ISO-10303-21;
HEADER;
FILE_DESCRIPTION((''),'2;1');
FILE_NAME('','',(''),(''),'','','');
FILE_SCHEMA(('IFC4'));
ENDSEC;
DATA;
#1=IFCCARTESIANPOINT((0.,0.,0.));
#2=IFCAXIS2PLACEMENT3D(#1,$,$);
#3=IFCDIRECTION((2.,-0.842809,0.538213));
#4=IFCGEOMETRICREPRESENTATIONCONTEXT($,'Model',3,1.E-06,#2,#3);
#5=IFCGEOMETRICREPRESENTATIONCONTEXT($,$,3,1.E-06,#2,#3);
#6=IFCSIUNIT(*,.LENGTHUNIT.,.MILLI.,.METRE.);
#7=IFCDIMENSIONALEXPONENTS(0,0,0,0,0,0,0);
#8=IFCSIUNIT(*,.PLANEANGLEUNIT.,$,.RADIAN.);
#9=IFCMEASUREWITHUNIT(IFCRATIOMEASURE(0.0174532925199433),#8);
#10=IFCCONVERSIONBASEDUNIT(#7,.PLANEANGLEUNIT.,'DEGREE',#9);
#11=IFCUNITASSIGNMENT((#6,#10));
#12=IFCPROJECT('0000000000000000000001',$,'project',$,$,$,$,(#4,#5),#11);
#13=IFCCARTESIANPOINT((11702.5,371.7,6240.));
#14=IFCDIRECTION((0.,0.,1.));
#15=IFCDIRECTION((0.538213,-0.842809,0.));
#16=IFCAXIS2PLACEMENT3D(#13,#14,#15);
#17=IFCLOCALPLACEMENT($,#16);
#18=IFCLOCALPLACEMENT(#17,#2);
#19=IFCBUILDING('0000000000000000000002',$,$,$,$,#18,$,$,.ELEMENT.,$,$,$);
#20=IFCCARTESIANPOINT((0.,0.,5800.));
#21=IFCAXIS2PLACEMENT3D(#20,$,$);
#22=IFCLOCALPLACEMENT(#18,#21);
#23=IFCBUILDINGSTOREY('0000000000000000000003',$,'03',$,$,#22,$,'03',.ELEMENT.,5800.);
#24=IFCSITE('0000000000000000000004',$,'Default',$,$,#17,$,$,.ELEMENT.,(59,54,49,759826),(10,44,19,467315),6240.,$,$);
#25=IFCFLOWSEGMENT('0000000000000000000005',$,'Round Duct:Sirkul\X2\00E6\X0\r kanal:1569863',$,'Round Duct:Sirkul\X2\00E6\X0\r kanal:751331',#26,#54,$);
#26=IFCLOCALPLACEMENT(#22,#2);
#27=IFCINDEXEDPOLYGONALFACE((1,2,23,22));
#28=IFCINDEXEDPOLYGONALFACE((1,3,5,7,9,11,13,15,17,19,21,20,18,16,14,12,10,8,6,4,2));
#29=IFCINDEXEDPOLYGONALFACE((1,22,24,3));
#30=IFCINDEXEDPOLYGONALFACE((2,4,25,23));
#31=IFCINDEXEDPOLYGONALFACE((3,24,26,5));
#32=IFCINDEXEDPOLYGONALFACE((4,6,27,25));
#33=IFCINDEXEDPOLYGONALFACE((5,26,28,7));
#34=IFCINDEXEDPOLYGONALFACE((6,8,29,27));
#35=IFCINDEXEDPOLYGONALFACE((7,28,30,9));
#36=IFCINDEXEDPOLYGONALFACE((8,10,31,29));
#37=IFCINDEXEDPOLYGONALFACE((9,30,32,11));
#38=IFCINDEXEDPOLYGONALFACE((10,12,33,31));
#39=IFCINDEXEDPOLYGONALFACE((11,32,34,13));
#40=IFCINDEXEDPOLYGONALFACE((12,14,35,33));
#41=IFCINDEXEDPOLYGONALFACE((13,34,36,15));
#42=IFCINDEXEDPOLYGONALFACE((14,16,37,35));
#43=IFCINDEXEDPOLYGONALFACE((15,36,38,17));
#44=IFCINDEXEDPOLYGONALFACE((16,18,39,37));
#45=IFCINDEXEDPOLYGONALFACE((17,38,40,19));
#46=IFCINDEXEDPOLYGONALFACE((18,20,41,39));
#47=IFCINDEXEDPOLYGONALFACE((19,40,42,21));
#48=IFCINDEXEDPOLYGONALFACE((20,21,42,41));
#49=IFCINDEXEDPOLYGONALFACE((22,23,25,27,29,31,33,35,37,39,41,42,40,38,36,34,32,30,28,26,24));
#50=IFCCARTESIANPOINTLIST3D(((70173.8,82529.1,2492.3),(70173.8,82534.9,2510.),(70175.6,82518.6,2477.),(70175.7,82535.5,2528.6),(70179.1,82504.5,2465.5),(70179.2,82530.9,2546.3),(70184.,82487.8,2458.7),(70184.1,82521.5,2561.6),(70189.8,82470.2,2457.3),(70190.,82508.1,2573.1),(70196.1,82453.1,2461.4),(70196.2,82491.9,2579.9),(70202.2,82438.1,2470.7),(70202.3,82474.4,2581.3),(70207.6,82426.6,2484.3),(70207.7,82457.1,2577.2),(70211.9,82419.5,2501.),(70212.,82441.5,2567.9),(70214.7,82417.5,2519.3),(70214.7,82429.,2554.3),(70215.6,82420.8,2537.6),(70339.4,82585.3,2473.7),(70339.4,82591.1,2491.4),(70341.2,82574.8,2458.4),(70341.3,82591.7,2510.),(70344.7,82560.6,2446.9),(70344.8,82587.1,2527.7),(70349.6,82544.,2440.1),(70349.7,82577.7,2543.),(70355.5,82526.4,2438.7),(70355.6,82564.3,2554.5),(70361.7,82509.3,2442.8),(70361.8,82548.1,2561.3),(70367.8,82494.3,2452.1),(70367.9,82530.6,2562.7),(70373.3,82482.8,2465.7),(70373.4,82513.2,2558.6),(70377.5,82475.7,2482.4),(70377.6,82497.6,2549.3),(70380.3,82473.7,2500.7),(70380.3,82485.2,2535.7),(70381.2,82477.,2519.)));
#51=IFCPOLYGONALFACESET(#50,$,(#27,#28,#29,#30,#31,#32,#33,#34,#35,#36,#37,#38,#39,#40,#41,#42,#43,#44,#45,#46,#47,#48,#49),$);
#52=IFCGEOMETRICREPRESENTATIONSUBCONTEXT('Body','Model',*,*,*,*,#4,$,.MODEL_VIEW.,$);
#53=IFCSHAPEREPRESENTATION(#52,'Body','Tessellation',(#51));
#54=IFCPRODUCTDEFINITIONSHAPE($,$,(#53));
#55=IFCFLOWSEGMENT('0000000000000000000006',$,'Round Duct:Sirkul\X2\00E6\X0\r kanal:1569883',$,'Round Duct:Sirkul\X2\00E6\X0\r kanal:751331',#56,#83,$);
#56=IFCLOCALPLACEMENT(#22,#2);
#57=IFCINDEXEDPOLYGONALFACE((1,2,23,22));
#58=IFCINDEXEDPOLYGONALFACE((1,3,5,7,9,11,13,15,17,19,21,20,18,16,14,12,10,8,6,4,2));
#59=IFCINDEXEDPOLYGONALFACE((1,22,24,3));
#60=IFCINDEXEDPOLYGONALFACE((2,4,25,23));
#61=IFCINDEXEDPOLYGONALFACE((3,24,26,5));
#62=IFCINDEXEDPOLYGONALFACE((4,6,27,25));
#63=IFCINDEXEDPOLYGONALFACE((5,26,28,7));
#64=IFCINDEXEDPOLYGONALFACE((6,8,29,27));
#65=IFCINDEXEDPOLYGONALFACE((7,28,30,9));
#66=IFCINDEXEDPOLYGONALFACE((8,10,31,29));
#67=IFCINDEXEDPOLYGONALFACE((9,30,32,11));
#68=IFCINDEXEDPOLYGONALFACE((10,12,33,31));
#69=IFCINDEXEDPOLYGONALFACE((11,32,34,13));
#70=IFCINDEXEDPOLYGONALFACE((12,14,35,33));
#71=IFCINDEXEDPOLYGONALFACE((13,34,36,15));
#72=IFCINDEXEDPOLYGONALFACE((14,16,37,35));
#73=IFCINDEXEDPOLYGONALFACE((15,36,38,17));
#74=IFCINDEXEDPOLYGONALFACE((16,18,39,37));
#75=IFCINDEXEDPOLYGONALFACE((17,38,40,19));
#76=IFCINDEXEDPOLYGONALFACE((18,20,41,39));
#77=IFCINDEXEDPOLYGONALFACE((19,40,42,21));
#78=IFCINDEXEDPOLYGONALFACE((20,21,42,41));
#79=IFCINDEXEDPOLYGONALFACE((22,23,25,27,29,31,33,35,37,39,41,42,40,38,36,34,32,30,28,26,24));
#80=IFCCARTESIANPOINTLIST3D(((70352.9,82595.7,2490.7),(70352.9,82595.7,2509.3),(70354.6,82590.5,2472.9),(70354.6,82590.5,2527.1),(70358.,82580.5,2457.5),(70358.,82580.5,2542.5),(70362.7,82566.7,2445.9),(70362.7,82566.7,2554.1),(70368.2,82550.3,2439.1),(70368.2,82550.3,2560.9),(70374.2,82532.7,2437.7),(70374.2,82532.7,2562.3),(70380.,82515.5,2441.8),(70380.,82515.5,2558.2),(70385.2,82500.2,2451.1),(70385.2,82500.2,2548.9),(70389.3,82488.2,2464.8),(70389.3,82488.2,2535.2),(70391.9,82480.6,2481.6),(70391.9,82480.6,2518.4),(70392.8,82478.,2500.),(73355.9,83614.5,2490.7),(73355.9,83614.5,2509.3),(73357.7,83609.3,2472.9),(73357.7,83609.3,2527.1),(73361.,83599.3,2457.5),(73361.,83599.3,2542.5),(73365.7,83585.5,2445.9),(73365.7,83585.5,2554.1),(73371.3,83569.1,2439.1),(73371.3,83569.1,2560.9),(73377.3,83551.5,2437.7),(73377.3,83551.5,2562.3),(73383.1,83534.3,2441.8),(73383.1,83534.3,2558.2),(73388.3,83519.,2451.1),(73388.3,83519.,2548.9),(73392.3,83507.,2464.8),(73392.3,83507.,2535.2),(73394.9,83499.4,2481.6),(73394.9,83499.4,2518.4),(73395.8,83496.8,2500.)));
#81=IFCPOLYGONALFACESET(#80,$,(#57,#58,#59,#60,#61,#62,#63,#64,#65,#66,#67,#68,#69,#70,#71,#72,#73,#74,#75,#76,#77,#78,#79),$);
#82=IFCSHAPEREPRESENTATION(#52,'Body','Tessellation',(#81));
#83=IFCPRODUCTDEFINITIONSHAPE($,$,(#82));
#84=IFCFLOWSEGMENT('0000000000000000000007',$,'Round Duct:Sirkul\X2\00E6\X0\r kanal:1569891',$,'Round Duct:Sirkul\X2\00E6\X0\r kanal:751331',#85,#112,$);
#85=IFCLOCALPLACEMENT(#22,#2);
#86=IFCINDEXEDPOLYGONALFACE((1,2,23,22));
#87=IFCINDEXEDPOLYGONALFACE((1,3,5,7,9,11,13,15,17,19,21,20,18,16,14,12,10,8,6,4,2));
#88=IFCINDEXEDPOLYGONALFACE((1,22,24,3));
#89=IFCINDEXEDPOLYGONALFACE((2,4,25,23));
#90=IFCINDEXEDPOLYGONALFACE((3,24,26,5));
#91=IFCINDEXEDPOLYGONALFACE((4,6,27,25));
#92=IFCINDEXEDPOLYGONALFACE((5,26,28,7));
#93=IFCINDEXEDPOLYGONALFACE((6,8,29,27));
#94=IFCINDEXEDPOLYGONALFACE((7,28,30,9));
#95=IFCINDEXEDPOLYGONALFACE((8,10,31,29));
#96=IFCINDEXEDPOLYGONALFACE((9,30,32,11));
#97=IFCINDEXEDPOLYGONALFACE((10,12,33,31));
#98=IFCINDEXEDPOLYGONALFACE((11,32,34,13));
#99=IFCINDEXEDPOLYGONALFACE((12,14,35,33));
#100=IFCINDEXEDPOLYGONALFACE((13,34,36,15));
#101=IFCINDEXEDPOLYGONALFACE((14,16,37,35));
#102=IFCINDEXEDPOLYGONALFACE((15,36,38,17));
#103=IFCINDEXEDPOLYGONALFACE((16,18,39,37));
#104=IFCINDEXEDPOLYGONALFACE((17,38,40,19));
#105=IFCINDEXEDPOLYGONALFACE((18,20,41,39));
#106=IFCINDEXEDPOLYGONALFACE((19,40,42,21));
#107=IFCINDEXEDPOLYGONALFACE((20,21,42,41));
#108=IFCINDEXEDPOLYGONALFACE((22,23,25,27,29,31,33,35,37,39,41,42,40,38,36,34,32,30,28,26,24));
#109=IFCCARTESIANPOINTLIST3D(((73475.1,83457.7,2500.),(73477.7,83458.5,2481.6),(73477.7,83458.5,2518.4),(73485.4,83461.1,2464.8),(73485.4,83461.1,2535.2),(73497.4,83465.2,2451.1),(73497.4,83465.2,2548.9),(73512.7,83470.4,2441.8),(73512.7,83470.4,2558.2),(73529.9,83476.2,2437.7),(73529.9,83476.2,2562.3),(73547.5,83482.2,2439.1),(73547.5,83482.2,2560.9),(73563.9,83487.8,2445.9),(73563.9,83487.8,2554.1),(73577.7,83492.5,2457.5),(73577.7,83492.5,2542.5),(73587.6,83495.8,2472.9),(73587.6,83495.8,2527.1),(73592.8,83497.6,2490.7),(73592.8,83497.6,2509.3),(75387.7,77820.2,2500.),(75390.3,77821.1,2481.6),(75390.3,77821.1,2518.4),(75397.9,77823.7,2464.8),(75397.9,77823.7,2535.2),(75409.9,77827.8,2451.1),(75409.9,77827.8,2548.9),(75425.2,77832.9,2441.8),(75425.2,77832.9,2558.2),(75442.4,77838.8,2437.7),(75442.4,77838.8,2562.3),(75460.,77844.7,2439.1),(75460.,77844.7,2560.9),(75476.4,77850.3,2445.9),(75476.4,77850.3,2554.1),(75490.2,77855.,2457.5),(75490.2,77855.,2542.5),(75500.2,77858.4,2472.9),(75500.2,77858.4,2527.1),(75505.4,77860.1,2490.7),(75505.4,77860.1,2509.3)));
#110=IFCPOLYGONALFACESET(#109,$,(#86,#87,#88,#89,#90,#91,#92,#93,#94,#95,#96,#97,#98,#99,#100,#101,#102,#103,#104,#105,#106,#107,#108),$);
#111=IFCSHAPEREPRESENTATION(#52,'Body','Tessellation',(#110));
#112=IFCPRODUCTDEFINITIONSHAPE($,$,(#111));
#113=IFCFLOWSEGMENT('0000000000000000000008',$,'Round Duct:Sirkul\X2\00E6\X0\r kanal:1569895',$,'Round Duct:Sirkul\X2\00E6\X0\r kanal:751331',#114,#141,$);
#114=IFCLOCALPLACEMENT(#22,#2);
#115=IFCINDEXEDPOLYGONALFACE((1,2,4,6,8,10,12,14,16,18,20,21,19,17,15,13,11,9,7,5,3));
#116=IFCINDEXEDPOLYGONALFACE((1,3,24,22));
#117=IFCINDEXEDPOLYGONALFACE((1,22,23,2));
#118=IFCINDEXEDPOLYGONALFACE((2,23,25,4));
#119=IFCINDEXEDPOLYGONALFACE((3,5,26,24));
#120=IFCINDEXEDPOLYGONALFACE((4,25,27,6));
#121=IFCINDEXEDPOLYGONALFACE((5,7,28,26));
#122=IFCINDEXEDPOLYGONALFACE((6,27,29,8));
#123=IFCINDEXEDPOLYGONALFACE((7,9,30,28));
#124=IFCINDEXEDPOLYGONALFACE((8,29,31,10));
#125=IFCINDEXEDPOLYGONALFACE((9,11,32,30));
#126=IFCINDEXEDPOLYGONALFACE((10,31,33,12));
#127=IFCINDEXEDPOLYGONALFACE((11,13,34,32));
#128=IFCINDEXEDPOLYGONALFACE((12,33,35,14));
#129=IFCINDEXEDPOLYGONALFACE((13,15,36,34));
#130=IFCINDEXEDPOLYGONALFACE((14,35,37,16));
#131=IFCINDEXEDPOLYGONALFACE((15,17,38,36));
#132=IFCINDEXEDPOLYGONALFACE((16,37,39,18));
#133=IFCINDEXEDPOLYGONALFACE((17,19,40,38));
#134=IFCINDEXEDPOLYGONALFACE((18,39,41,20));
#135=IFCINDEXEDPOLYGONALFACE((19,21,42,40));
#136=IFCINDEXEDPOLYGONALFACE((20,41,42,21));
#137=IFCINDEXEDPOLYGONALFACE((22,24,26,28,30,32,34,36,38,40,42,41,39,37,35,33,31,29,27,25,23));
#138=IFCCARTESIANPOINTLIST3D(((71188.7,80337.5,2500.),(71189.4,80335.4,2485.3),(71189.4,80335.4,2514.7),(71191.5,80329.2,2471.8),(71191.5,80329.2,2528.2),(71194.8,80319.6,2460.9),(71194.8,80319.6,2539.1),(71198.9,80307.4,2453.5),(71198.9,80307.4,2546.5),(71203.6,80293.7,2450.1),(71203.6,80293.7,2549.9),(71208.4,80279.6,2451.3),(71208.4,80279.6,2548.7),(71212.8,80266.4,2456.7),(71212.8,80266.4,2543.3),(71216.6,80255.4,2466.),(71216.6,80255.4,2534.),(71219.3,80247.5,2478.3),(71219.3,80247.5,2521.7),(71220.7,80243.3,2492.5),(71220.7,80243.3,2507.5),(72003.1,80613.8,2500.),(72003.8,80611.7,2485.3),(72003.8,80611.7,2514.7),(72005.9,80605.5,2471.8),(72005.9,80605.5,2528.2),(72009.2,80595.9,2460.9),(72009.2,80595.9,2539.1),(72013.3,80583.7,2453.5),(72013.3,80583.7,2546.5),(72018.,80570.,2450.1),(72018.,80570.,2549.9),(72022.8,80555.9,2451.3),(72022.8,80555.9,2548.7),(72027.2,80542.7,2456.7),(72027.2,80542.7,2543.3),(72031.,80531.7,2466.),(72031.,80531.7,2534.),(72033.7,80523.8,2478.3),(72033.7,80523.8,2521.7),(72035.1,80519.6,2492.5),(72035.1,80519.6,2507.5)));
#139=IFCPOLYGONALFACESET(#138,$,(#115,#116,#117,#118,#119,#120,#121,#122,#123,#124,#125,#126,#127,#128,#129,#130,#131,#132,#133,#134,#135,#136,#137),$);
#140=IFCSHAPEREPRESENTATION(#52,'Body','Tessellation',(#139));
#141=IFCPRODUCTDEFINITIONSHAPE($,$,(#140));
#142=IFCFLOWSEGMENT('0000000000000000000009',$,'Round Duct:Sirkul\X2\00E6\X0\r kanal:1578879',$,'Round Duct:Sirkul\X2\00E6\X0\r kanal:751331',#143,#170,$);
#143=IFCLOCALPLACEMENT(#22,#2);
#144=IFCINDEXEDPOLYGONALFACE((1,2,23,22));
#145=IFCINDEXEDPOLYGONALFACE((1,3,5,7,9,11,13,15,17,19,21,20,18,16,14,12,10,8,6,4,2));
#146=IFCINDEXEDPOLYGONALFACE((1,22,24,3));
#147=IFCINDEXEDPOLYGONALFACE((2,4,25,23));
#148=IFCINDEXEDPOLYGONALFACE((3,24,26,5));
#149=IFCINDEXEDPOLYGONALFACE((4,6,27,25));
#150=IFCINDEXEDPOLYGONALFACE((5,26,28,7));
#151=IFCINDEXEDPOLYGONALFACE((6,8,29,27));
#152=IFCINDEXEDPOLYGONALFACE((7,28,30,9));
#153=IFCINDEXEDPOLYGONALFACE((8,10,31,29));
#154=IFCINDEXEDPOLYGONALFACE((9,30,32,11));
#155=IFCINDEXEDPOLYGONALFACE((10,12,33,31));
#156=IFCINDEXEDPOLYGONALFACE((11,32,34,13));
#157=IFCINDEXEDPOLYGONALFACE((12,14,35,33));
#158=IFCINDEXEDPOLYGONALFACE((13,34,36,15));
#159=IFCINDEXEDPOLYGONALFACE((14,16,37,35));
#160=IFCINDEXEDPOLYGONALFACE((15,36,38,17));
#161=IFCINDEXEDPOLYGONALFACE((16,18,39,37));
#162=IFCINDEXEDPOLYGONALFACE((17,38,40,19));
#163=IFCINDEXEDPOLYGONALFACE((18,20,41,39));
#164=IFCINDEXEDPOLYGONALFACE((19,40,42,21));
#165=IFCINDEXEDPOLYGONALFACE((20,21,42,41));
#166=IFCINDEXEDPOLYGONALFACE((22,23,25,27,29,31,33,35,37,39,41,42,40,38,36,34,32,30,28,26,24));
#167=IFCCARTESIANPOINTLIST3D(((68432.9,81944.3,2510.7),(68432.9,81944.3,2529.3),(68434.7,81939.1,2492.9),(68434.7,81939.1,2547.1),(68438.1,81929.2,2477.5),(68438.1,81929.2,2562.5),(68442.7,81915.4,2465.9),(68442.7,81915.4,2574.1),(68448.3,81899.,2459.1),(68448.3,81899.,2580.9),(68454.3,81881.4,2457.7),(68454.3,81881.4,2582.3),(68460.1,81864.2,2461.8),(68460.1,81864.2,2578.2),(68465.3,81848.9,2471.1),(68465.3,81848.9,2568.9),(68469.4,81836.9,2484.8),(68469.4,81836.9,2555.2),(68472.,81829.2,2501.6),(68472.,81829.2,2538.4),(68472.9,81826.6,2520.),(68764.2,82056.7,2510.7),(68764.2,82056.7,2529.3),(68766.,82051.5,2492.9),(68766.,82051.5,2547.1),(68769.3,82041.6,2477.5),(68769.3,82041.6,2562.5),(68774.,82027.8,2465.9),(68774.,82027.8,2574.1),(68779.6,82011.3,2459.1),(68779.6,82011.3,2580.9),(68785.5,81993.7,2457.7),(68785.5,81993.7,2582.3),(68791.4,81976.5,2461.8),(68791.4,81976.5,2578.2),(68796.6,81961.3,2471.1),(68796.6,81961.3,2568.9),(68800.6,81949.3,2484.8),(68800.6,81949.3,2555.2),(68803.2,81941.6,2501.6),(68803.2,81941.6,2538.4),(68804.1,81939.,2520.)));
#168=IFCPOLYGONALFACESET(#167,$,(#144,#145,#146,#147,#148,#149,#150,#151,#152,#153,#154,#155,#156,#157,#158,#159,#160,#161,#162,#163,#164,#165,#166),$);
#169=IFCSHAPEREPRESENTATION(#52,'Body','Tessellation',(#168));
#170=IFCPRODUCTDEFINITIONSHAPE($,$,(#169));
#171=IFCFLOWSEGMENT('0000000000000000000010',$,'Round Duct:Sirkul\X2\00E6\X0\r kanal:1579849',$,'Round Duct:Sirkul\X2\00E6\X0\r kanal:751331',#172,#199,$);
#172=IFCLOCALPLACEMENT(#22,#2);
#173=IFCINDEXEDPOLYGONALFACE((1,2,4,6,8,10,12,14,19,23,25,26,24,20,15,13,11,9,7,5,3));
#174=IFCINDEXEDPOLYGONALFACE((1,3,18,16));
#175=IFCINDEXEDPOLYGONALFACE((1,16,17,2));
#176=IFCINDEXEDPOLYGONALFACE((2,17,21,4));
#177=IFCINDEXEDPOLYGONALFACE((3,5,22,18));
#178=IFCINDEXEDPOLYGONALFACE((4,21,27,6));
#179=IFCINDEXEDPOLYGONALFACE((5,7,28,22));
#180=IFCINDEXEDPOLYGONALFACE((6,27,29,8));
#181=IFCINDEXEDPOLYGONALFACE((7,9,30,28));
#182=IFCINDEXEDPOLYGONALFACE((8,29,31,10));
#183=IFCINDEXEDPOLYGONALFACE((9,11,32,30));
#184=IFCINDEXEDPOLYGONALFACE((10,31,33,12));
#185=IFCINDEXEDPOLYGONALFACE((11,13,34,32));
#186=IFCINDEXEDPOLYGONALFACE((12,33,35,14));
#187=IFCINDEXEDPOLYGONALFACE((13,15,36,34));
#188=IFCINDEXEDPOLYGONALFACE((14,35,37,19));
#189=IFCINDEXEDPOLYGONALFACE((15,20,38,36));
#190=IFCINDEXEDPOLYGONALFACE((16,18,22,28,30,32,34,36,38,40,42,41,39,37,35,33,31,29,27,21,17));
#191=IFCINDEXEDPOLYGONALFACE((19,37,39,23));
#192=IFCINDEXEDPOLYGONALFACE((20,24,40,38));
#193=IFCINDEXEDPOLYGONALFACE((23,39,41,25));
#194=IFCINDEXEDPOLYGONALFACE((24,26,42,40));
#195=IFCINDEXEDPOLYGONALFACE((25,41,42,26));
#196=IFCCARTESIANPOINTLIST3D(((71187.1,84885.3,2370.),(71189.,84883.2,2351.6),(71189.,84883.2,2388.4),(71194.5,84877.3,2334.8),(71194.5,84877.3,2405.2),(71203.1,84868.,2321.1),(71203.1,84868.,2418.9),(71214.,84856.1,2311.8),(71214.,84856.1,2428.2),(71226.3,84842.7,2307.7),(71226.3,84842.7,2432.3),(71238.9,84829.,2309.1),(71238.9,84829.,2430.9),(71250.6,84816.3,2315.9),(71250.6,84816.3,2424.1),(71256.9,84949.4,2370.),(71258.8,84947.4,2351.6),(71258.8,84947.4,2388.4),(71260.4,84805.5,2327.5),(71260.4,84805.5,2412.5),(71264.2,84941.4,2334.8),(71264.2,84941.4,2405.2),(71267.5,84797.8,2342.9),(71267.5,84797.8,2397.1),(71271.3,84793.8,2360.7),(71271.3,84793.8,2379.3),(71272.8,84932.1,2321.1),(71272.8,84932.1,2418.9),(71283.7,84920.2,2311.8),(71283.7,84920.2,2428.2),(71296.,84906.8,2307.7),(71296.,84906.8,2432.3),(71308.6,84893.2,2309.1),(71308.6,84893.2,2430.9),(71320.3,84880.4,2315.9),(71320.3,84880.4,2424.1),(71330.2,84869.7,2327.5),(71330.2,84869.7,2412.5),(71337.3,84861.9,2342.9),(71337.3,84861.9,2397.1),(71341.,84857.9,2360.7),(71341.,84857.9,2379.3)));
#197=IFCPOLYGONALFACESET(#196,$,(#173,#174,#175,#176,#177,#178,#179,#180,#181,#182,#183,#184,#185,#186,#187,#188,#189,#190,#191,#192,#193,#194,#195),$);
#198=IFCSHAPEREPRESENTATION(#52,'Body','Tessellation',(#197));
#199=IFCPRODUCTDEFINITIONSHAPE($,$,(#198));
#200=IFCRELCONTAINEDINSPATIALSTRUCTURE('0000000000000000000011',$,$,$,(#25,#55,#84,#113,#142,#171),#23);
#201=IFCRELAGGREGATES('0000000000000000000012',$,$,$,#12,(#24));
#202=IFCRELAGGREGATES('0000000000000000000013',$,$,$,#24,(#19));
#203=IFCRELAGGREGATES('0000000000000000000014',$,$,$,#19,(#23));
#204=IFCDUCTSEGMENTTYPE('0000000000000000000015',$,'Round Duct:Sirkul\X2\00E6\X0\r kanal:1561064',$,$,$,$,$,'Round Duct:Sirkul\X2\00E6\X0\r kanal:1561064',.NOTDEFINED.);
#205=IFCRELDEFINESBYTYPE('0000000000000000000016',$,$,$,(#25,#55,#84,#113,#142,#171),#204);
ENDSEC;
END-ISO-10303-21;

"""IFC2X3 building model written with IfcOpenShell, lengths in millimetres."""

from ifc_helpers import new_model, entity, si_unit, converted_unit, direction, frame, frame_2d, origin, origin_2d_with_axis, place, context, subcontext, project, spatial, circle, extrude, type_object, element, save


model = new_model("IFC2X3")

# Units and contexts
model_context = context("Model", 3, precision=1e-06, world=origin(), true_north=direction((2.0, -0.842809, 0.538213)))
context_of_model = context(None, 3, precision=1e-06, world=origin(), true_north=direction((2.0, -0.842809, 0.538213)))
body_context = subcontext(model_context, "Body", "Model", "MODEL_VIEW")
ifc_project = project(units=[si_unit("LENGTHUNIT", "METRE", prefix="MILLI"), converted_unit("PLANEANGLEUNIT", "DEGREE", entity("IfcRatioMeasure", 0.0174532925199433), si_unit("PLANEANGLEUNIT", "RADIAN"), dimensions=[0, 0, 0, 0, 0, 0, 0])], contexts=[model_context, context_of_model])

# Site, building, storey
site_placement = place(None, frame((11702.5, 371.7, 6240.0), z_axis=(0.0, 0.0, 1.0), x_axis=(0.538213, -0.842809, 0.0)))
site = spatial("IfcSite", under=ifc_project, at=site_placement, Name="Default", CompositionType="ELEMENT", RefLatitude=(59, 54, 49, 759826), RefLongitude=(10, 44, 19, 467315), RefElevation=6240.0)
building_placement = place(site_placement, origin())
building = spatial("IfcBuilding", under=site, at=building_placement, CompositionType="ELEMENT")
storey_placement = place(building_placement, frame((0.0, 0.0, 5800.0)))
storey = spatial("IfcBuildingStorey", under=building, at=storey_placement, Name="03", LongName="03", CompositionType="ELEMENT", Elevation=5800.0)

# Flow segments
duct_segment_type = type_object("IfcDuctSegmentType", Name="Round Duct:Sirkulær kanal:1561064", ElementType="Round Duct:Sirkulær kanal:1561064", PredefinedType="NOTDEFINED")
flow_segment_1_placement = place(storey_placement, origin())
element("IfcFlowSegment", 1, at=flow_segment_1_placement, inside=storey, type_object=duct_segment_type, Name="Round Duct:Sirkulær kanal:1569863", ObjectType="Round Duct:Sirkulær kanal:751331", context=body_context, shape_type="SweptSolid", body=[
    extrude(circle(Radius=62.5, at=frame_2d((0.0, 0.0), x_axis=(1.0, 0.0))), frame((70360.2, 82532.9, 2500.7), z_axis=(-0.941677, -0.319473, 0.105746), x_axis=(0.321274, -0.946986, 0.0)), (0.0, 0.0, 1.0), 175.9),
])
flow_segment_2_placement = place(storey_placement, origin())
element("IfcFlowSegment", 2, at=flow_segment_2_placement, inside=storey, type_object=duct_segment_type, Name="Round Duct:Sirkulær kanal:1569883", ObjectType="Round Duct:Sirkulær kanal:751331", context=body_context, shape_type="SweptSolid", body=[
    extrude(circle(Radius=62.5, at=origin_2d_with_axis()), frame((70372.7, 82537.1, 2500.0), z_axis=(0.946986, 0.321274, 0.0), x_axis=(0.321274, -0.946986, 0.0)), (0.0, 0.0, 1.0), 3171.2),
])
flow_segment_3_placement = place(storey_placement, origin())
element("IfcFlowSegment", 3, at=flow_segment_3_placement, inside=storey, type_object=duct_segment_type, Name="Round Duct:Sirkulær kanal:1569891", ObjectType="Round Duct:Sirkulær kanal:751331", context=body_context, shape_type="SweptSolid", body=[
    extrude(circle(Radius=62.5, at=frame_2d((0.0, 0.0), x_axis=(1.0, 0.0))), frame((73534.3, 83477.7, 2500.0), z_axis=(0.321274, -0.946986, 0.0), x_axis=(-0.946986, -0.321274, 0.0)), (0.0, 0.0, 1.0), 5953.1),
])
flow_segment_4_placement = place(storey_placement, origin())
element("IfcFlowSegment", 4, at=flow_segment_4_placement, inside=storey, type_object=duct_segment_type, Name="Round Duct:Sirkulær kanal:1569895", ObjectType="Round Duct:Sirkulær kanal:751331", context=body_context, shape_type="SweptSolid", body=[
    extrude(circle(Radius=50.0, at=origin_2d_with_axis()), frame((71204.8, 80290.1, 2500.0), z_axis=(0.946986, 0.321274, 0.0), x_axis=(-0.321274, 0.946986, 0.0)), (0.0, 0.0, 1.0), 860.0),
])
flow_segment_5_placement = place(storey_placement, origin())
element("IfcFlowSegment", 5, at=flow_segment_5_placement, inside=storey, type_object=duct_segment_type, Name="Round Duct:Sirkulær kanal:1578879", ObjectType="Round Duct:Sirkulær kanal:751331", context=body_context, shape_type="SweptSolid", body=[
    extrude(circle(Radius=62.5, at=origin_2d_with_axis()), frame((68452.8, 81885.8, 2520.0), z_axis=(0.946986, 0.321274, 0.0), x_axis=(0.321274, -0.946986, 0.0)), (0.0, 0.0, 1.0), 349.8),
])
flow_segment_6_placement = place(storey_placement, origin())
element("IfcFlowSegment", 6, at=flow_segment_6_placement, inside=storey, type_object=duct_segment_type, Name="Round Duct:Sirkulær kanal:1579849", ObjectType="Round Duct:Sirkulær kanal:751331", context=body_context, shape_type="SweptSolid", body=[
    extrude(circle(Radius=62.5, at=origin_2d_with_axis()), frame((71229.4, 84839.3, 2370.0), z_axis=(0.736176, 0.67679, 0.0), x_axis=(-0.67679, 0.736176, 0.0)), (0.0, 0.0, 1.0), 94.7),
])

save(model, "model.ifc")
